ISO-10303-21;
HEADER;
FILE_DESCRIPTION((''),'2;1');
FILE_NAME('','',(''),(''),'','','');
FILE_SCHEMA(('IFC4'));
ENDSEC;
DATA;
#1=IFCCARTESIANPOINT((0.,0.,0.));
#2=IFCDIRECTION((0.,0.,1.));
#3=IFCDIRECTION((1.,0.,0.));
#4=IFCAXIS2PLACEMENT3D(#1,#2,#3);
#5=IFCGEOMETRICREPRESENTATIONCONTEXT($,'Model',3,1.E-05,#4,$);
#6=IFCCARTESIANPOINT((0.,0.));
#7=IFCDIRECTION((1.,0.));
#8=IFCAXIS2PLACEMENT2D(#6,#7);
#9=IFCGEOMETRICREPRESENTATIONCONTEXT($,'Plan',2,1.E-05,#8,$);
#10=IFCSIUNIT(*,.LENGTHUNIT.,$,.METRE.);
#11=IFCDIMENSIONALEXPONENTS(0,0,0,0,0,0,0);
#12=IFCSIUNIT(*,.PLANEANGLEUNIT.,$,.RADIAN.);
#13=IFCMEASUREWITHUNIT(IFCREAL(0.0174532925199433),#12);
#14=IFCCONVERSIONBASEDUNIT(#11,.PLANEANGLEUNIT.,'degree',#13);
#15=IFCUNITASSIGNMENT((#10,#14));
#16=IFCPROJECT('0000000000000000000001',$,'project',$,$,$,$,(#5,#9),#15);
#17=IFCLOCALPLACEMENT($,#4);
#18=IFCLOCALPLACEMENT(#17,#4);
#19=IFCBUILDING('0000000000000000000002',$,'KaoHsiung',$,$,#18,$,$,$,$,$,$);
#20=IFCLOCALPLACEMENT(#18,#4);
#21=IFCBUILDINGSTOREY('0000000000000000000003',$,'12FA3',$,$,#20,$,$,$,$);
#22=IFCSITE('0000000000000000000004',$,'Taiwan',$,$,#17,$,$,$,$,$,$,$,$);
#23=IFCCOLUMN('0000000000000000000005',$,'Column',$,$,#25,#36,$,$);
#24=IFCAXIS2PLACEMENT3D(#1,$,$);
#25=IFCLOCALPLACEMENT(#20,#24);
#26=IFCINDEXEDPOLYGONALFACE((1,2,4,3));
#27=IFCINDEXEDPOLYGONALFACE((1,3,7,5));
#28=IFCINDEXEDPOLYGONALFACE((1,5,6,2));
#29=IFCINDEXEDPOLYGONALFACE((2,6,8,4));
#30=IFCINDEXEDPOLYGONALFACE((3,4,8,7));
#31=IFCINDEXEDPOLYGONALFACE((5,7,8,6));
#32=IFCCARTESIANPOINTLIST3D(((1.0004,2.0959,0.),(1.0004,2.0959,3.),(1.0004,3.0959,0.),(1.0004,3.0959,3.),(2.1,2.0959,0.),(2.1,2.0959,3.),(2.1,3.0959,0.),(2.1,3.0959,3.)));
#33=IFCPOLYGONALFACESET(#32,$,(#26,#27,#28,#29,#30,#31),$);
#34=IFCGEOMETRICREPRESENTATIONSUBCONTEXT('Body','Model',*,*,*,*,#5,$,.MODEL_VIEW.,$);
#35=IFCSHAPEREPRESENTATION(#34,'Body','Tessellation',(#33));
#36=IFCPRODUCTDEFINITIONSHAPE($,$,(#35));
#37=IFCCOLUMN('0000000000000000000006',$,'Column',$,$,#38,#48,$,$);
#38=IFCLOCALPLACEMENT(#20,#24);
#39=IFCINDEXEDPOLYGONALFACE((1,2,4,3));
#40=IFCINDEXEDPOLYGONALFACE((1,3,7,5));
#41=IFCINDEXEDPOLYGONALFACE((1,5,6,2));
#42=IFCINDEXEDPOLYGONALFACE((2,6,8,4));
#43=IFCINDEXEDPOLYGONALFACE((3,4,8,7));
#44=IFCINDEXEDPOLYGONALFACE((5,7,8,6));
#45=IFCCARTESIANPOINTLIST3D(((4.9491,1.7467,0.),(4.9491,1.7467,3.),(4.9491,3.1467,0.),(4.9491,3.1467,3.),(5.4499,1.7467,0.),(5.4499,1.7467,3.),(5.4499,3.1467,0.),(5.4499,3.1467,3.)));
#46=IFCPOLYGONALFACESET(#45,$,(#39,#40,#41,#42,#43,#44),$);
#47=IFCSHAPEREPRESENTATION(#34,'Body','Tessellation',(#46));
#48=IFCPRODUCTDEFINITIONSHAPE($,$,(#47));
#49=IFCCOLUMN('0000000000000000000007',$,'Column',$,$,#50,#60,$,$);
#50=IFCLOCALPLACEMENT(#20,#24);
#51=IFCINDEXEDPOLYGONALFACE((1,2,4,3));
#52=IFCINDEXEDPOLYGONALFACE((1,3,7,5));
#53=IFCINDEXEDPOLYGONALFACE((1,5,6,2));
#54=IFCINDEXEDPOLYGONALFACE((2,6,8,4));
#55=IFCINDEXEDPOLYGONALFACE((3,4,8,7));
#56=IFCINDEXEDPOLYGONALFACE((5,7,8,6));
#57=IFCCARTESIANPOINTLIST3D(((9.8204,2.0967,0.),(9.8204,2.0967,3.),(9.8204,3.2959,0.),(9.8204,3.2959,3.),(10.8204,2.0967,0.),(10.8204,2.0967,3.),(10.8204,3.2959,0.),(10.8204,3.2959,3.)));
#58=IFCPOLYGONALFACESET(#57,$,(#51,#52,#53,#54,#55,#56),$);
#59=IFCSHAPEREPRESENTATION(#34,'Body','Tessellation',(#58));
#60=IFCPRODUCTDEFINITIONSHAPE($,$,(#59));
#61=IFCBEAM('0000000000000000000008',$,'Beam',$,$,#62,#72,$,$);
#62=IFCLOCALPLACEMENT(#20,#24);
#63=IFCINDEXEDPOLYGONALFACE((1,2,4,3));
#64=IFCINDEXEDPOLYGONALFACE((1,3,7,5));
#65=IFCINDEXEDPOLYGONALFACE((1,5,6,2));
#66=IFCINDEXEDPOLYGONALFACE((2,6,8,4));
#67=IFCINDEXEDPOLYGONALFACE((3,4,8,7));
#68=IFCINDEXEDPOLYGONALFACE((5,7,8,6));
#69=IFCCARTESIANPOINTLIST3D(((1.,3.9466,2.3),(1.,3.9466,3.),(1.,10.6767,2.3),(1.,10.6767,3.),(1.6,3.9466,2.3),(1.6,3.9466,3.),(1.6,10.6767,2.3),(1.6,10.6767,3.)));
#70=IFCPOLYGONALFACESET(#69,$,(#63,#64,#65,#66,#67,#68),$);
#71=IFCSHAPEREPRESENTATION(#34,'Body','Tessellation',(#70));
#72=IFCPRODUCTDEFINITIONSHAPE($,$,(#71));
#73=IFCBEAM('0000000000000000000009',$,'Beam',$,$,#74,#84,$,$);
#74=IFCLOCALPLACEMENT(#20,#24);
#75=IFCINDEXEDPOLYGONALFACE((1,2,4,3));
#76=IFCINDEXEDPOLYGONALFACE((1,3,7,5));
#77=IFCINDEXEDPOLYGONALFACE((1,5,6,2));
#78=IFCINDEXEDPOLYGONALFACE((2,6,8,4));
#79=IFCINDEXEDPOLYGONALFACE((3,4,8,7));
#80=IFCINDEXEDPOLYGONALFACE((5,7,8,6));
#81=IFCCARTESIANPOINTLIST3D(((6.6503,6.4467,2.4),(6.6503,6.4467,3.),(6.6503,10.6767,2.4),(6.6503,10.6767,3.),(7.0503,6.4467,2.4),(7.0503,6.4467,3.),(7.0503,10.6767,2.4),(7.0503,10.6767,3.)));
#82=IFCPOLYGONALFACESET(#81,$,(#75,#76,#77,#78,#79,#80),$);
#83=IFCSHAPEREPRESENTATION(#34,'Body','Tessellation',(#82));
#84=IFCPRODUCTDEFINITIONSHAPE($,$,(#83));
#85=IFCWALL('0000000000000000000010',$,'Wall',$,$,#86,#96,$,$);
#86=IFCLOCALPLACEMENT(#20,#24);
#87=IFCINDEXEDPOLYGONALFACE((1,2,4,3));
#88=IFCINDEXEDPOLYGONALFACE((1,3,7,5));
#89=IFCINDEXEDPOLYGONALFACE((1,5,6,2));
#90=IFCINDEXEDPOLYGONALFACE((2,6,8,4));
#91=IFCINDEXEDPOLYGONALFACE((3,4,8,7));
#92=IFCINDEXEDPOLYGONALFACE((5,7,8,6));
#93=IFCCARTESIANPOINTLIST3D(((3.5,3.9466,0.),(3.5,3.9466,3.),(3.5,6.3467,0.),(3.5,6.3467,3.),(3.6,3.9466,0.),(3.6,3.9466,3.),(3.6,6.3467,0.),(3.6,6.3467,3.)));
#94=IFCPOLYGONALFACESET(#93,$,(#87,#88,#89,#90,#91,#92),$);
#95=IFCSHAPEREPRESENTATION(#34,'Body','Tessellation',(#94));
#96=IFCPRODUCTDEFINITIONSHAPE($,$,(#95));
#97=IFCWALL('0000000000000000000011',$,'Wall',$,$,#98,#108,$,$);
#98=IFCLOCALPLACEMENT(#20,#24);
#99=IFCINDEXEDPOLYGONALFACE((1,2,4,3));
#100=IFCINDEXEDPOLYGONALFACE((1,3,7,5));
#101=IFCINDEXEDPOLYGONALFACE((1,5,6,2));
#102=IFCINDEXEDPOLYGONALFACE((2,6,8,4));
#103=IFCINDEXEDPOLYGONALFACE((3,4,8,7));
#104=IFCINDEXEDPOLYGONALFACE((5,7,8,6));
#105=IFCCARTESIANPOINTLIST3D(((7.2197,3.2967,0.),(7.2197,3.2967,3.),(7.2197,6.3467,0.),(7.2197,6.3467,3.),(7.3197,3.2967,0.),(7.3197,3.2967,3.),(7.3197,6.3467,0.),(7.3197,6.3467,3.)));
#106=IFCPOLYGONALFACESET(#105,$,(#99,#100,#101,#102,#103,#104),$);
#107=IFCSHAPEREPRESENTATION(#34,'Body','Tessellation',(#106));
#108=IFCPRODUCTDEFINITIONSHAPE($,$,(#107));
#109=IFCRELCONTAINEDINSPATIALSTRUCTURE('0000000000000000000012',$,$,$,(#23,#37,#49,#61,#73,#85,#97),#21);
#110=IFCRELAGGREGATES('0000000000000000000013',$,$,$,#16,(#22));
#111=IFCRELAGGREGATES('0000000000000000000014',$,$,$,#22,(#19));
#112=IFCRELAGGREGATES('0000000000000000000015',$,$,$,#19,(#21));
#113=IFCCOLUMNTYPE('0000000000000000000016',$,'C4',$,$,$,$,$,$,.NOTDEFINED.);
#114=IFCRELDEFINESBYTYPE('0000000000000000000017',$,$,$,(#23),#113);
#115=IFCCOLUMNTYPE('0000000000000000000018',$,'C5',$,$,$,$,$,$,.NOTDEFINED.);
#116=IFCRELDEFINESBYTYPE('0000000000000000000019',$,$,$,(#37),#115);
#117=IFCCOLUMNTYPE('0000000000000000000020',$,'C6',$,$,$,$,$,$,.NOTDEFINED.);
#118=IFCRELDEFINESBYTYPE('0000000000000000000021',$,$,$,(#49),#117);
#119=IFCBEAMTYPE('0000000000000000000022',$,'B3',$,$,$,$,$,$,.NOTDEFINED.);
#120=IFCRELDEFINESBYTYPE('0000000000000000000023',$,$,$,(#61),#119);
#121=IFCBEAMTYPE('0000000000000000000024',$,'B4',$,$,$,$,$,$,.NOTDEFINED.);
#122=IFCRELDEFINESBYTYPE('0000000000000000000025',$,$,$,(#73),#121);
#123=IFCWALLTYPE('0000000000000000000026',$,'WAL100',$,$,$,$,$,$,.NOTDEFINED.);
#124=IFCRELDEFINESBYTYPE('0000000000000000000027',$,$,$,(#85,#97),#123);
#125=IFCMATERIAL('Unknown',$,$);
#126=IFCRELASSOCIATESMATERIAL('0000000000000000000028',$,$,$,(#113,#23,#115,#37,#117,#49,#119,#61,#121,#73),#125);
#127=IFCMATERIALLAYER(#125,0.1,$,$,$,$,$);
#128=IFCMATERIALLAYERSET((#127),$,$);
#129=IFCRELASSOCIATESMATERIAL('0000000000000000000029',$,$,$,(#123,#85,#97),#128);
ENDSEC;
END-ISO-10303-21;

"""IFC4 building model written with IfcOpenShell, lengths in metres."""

from ifc_helpers import new_model, entity, si_unit, converted_unit, frame, origin_with_axes, origin_2d_with_axis, place, context, subcontext, project, spatial, line, indexed_curve, rectangle, outline, extrude, material, layer, layer_set, layer_usage, material_profile, profile_set, profile_usage, type_object, element, save


model = new_model("IFC4")

# Units and contexts
model_context = context("Model", 3, precision=1e-05, world=origin_with_axes())
plan_context = context("Plan", 2, precision=1e-05, world=origin_2d_with_axis())
body_context_1 = subcontext(model_context, "Body", "Model", "MODEL_VIEW")
ifc_project = project(units=[si_unit("LENGTHUNIT", "METRE"), converted_unit("PLANEANGLEUNIT", "degree", entity("IfcReal", 0.0174532925199433), si_unit("PLANEANGLEUNIT", "RADIAN"), dimensions=[0, 0, 0, 0, 0, 0, 0])], contexts=[model_context, plan_context])

# Site, building, storey
site_placement = place(None, origin_with_axes())
site = spatial("IfcSite", under=ifc_project, at=site_placement, Name="Taiwan")
building_placement = place(site_placement, origin_with_axes())
building = spatial("IfcBuilding", under=site, at=building_placement, Name="KaoHsiung")
storey_placement = place(building_placement, origin_with_axes())
storey = spatial("IfcBuildingStorey", under=building, at=storey_placement, Name="12FA3")

# Columns
ifc_material = material(Name="Unknown")
ifc_material_profile_1 = material_profile(ifc_material, outline(indexed_curve([(0.0, 1.0), (1.0995, 1.0), (1.0995, 0.0), (0.0, 0.0), (0.0, 1.0)])))
ifc_profile_set_1 = profile_set([ifc_material_profile_1])
ifc_profile_usage_1 = profile_usage(ifc_profile_set_1, cardinal=5)
column_type_1 = type_object("IfcColumnType", Name="C4", PredefinedType="NOTDEFINED", material=ifc_profile_set_1)
column_1_placement = place(storey_placement, frame((1.0004, 2.0959, 0.0), z_axis=(0.0, 0.0, 1.0), x_axis=(1.0, 0.0, 0.0)))
element("IfcColumn", 1, at=column_1_placement, inside=storey, type_object=column_type_1, material=ifc_profile_usage_1, Name="Column", context=body_context_1, shape_type="SweptSolid", body=[
    extrude(outline(indexed_curve([(0.0, 1.0), (1.0995, 1.0), (1.0995, 0.0), (0.0, 0.0), (0.0, 1.0)])), origin_with_axes(), (0.0, 0.0, 1.0), 3.0),
])
ifc_material_profile_2 = material_profile(ifc_material, outline(indexed_curve([(0.0, 0.0), (0.5008, 0.0), (0.5008, 1.4), (0.0, 1.4), (0.0, 0.0)])))
ifc_profile_set_2 = profile_set([ifc_material_profile_2])
ifc_profile_usage_2 = profile_usage(ifc_profile_set_2, cardinal=5)
column_type_2 = type_object("IfcColumnType", Name="C5", PredefinedType="NOTDEFINED", material=ifc_profile_set_2)
column_2_placement = place(storey_placement, frame((4.9491, 1.7467, 0.0), z_axis=(0.0, 0.0, 1.0), x_axis=(1.0, 0.0, 0.0)))
element("IfcColumn", 2, at=column_2_placement, inside=storey, type_object=column_type_2, material=ifc_profile_usage_2, Name="Column", context=body_context_1, shape_type="SweptSolid", body=[
    extrude(outline(indexed_curve([(0.0, 0.0), (0.5008, 0.0), (0.5008, 1.4), (0.0, 1.4), (0.0, 0.0)])), origin_with_axes(), (0.0, 0.0, 1.0), 3.0),
])
ifc_material_profile_3 = material_profile(ifc_material, outline(indexed_curve([(0.0, 1.1992), (1.0, 1.1992), (1.0, 0.0), (0.0, 0.0), (0.0, 1.1992)])))
ifc_profile_set_3 = profile_set([ifc_material_profile_3])
ifc_profile_usage_3 = profile_usage(ifc_profile_set_3, cardinal=5)
column_type_3 = type_object("IfcColumnType", Name="C6", PredefinedType="NOTDEFINED", material=ifc_profile_set_3)
column_3_placement = place(storey_placement, frame((9.8204, 2.0967, 0.0), z_axis=(0.0, 0.0, 1.0), x_axis=(1.0, 0.0, 0.0)))
element("IfcColumn", 3, at=column_3_placement, inside=storey, type_object=column_type_3, material=ifc_profile_usage_3, Name="Column", context=body_context_1, shape_type="SweptSolid", body=[
    extrude(outline(indexed_curve([(0.0, 1.1992), (1.0, 1.1992), (1.0, 0.0), (0.0, 0.0), (0.0, 1.1992)])), origin_with_axes(), (0.0, 0.0, 1.0), 3.0),
])

# Beams
ifc_material_profile_4 = material_profile(ifc_material, rectangle(XDim=0.6, YDim=0.7, kind="CURVE"))
ifc_profile_set_4 = profile_set([ifc_material_profile_4])
ifc_profile_usage_4 = profile_usage(ifc_profile_set_4, cardinal=7)
beam_type_1 = type_object("IfcBeamType", Name="B3", PredefinedType="NOTDEFINED", material=ifc_profile_set_4)
beam_1_placement = place(storey_placement, frame((1.0, 3.9466, 3.0), z_axis=(0.0, 1.0, 0.0), x_axis=(-1.0, 0.0, 0.0)))
element("IfcBeam", 4, at=beam_1_placement, inside=storey, type_object=beam_type_1, material=ifc_profile_usage_4, Name="Beam", context=body_context_1, shape_type="SweptSolid", body=[
    extrude(rectangle(XDim=0.6, YDim=0.7, kind="CURVE"), frame((-0.3, -0.35, 0.0), z_axis=(0.0, 0.0, 1.0), x_axis=(1.0, 0.0, 0.0)), (0.0, 0.0, 1.0), 6.7301),
])
ifc_material_profile_5 = material_profile(ifc_material, rectangle(XDim=0.4, YDim=0.6, kind="CURVE"))
ifc_profile_set_5 = profile_set([ifc_material_profile_5])
ifc_profile_usage_5 = profile_usage(ifc_profile_set_5, cardinal=7)
beam_type_2 = type_object("IfcBeamType", Name="B4", PredefinedType="NOTDEFINED", material=ifc_profile_set_5)
beam_2_placement = place(storey_placement, frame((6.6503, 6.4467, 3.0), z_axis=(0.0, 1.0, 0.0), x_axis=(-1.0, 0.0, 0.0)))
element("IfcBeam", 5, at=beam_2_placement, inside=storey, type_object=beam_type_2, material=ifc_profile_usage_5, Name="Beam", context=body_context_1, shape_type="SweptSolid", body=[
    extrude(rectangle(XDim=0.4, YDim=0.6, kind="CURVE"), frame((-0.2, -0.3, 0.0), z_axis=(0.0, 0.0, 1.0), x_axis=(1.0, 0.0, 0.0)), (0.0, 0.0, 1.0), 4.23),
])

# Walls
ifc_layer_1 = layer(ifc_material, 0.1)
ifc_layer_set_1 = layer_set([ifc_layer_1])
ifc_layer_usage_1 = layer_usage(ifc_layer_set_1, "AXIS2", "POSITIVE", 0.0)
wall_type_1 = type_object("IfcWallType", Name="WAL100", PredefinedType="NOTDEFINED", material=ifc_layer_set_1)
wall_1_placement = place(storey_placement, frame((3.6, 3.9466, 0.0), z_axis=(0.0, 0.0, 1.0), x_axis=(0.0, 1.0, 0.0)))
element("IfcWall", 6, at=wall_1_placement, inside=storey, type_object=wall_type_1, material=ifc_layer_usage_1, Name="Wall", context=body_context_1, shape_type="SweptSolid", body=[
    extrude(outline(indexed_curve([(0.0, 0.0), (0.0, 0.1), (2.4001, 0.1), (2.4001, 0.0)], segments=[line(1, 2, 3, 4, 1)])), origin_with_axes(), (0.0, 0.0, 1.0), 3.0),
])
ifc_layer_usage_2 = layer_usage(ifc_layer_set_1, "AXIS2", "POSITIVE", 0.0)
wall_2_placement = place(storey_placement, frame((7.3197, 3.2967, 0.0), z_axis=(0.0, 0.0, 1.0), x_axis=(0.0, 1.0, 0.0)))
element("IfcWall", 7, at=wall_2_placement, inside=storey, type_object=wall_type_1, material=ifc_layer_usage_2, Name="Wall", context=body_context_1, shape_type="SweptSolid", body=[
    extrude(outline(indexed_curve([(0.0, 0.0), (0.0, 0.1), (3.05, 0.1), (3.05, 0.0)], segments=[line(1, 2, 3, 4, 1)])), origin_with_axes(), (0.0, 0.0, 1.0), 3.0),
])

save(model, "model.ifc")
